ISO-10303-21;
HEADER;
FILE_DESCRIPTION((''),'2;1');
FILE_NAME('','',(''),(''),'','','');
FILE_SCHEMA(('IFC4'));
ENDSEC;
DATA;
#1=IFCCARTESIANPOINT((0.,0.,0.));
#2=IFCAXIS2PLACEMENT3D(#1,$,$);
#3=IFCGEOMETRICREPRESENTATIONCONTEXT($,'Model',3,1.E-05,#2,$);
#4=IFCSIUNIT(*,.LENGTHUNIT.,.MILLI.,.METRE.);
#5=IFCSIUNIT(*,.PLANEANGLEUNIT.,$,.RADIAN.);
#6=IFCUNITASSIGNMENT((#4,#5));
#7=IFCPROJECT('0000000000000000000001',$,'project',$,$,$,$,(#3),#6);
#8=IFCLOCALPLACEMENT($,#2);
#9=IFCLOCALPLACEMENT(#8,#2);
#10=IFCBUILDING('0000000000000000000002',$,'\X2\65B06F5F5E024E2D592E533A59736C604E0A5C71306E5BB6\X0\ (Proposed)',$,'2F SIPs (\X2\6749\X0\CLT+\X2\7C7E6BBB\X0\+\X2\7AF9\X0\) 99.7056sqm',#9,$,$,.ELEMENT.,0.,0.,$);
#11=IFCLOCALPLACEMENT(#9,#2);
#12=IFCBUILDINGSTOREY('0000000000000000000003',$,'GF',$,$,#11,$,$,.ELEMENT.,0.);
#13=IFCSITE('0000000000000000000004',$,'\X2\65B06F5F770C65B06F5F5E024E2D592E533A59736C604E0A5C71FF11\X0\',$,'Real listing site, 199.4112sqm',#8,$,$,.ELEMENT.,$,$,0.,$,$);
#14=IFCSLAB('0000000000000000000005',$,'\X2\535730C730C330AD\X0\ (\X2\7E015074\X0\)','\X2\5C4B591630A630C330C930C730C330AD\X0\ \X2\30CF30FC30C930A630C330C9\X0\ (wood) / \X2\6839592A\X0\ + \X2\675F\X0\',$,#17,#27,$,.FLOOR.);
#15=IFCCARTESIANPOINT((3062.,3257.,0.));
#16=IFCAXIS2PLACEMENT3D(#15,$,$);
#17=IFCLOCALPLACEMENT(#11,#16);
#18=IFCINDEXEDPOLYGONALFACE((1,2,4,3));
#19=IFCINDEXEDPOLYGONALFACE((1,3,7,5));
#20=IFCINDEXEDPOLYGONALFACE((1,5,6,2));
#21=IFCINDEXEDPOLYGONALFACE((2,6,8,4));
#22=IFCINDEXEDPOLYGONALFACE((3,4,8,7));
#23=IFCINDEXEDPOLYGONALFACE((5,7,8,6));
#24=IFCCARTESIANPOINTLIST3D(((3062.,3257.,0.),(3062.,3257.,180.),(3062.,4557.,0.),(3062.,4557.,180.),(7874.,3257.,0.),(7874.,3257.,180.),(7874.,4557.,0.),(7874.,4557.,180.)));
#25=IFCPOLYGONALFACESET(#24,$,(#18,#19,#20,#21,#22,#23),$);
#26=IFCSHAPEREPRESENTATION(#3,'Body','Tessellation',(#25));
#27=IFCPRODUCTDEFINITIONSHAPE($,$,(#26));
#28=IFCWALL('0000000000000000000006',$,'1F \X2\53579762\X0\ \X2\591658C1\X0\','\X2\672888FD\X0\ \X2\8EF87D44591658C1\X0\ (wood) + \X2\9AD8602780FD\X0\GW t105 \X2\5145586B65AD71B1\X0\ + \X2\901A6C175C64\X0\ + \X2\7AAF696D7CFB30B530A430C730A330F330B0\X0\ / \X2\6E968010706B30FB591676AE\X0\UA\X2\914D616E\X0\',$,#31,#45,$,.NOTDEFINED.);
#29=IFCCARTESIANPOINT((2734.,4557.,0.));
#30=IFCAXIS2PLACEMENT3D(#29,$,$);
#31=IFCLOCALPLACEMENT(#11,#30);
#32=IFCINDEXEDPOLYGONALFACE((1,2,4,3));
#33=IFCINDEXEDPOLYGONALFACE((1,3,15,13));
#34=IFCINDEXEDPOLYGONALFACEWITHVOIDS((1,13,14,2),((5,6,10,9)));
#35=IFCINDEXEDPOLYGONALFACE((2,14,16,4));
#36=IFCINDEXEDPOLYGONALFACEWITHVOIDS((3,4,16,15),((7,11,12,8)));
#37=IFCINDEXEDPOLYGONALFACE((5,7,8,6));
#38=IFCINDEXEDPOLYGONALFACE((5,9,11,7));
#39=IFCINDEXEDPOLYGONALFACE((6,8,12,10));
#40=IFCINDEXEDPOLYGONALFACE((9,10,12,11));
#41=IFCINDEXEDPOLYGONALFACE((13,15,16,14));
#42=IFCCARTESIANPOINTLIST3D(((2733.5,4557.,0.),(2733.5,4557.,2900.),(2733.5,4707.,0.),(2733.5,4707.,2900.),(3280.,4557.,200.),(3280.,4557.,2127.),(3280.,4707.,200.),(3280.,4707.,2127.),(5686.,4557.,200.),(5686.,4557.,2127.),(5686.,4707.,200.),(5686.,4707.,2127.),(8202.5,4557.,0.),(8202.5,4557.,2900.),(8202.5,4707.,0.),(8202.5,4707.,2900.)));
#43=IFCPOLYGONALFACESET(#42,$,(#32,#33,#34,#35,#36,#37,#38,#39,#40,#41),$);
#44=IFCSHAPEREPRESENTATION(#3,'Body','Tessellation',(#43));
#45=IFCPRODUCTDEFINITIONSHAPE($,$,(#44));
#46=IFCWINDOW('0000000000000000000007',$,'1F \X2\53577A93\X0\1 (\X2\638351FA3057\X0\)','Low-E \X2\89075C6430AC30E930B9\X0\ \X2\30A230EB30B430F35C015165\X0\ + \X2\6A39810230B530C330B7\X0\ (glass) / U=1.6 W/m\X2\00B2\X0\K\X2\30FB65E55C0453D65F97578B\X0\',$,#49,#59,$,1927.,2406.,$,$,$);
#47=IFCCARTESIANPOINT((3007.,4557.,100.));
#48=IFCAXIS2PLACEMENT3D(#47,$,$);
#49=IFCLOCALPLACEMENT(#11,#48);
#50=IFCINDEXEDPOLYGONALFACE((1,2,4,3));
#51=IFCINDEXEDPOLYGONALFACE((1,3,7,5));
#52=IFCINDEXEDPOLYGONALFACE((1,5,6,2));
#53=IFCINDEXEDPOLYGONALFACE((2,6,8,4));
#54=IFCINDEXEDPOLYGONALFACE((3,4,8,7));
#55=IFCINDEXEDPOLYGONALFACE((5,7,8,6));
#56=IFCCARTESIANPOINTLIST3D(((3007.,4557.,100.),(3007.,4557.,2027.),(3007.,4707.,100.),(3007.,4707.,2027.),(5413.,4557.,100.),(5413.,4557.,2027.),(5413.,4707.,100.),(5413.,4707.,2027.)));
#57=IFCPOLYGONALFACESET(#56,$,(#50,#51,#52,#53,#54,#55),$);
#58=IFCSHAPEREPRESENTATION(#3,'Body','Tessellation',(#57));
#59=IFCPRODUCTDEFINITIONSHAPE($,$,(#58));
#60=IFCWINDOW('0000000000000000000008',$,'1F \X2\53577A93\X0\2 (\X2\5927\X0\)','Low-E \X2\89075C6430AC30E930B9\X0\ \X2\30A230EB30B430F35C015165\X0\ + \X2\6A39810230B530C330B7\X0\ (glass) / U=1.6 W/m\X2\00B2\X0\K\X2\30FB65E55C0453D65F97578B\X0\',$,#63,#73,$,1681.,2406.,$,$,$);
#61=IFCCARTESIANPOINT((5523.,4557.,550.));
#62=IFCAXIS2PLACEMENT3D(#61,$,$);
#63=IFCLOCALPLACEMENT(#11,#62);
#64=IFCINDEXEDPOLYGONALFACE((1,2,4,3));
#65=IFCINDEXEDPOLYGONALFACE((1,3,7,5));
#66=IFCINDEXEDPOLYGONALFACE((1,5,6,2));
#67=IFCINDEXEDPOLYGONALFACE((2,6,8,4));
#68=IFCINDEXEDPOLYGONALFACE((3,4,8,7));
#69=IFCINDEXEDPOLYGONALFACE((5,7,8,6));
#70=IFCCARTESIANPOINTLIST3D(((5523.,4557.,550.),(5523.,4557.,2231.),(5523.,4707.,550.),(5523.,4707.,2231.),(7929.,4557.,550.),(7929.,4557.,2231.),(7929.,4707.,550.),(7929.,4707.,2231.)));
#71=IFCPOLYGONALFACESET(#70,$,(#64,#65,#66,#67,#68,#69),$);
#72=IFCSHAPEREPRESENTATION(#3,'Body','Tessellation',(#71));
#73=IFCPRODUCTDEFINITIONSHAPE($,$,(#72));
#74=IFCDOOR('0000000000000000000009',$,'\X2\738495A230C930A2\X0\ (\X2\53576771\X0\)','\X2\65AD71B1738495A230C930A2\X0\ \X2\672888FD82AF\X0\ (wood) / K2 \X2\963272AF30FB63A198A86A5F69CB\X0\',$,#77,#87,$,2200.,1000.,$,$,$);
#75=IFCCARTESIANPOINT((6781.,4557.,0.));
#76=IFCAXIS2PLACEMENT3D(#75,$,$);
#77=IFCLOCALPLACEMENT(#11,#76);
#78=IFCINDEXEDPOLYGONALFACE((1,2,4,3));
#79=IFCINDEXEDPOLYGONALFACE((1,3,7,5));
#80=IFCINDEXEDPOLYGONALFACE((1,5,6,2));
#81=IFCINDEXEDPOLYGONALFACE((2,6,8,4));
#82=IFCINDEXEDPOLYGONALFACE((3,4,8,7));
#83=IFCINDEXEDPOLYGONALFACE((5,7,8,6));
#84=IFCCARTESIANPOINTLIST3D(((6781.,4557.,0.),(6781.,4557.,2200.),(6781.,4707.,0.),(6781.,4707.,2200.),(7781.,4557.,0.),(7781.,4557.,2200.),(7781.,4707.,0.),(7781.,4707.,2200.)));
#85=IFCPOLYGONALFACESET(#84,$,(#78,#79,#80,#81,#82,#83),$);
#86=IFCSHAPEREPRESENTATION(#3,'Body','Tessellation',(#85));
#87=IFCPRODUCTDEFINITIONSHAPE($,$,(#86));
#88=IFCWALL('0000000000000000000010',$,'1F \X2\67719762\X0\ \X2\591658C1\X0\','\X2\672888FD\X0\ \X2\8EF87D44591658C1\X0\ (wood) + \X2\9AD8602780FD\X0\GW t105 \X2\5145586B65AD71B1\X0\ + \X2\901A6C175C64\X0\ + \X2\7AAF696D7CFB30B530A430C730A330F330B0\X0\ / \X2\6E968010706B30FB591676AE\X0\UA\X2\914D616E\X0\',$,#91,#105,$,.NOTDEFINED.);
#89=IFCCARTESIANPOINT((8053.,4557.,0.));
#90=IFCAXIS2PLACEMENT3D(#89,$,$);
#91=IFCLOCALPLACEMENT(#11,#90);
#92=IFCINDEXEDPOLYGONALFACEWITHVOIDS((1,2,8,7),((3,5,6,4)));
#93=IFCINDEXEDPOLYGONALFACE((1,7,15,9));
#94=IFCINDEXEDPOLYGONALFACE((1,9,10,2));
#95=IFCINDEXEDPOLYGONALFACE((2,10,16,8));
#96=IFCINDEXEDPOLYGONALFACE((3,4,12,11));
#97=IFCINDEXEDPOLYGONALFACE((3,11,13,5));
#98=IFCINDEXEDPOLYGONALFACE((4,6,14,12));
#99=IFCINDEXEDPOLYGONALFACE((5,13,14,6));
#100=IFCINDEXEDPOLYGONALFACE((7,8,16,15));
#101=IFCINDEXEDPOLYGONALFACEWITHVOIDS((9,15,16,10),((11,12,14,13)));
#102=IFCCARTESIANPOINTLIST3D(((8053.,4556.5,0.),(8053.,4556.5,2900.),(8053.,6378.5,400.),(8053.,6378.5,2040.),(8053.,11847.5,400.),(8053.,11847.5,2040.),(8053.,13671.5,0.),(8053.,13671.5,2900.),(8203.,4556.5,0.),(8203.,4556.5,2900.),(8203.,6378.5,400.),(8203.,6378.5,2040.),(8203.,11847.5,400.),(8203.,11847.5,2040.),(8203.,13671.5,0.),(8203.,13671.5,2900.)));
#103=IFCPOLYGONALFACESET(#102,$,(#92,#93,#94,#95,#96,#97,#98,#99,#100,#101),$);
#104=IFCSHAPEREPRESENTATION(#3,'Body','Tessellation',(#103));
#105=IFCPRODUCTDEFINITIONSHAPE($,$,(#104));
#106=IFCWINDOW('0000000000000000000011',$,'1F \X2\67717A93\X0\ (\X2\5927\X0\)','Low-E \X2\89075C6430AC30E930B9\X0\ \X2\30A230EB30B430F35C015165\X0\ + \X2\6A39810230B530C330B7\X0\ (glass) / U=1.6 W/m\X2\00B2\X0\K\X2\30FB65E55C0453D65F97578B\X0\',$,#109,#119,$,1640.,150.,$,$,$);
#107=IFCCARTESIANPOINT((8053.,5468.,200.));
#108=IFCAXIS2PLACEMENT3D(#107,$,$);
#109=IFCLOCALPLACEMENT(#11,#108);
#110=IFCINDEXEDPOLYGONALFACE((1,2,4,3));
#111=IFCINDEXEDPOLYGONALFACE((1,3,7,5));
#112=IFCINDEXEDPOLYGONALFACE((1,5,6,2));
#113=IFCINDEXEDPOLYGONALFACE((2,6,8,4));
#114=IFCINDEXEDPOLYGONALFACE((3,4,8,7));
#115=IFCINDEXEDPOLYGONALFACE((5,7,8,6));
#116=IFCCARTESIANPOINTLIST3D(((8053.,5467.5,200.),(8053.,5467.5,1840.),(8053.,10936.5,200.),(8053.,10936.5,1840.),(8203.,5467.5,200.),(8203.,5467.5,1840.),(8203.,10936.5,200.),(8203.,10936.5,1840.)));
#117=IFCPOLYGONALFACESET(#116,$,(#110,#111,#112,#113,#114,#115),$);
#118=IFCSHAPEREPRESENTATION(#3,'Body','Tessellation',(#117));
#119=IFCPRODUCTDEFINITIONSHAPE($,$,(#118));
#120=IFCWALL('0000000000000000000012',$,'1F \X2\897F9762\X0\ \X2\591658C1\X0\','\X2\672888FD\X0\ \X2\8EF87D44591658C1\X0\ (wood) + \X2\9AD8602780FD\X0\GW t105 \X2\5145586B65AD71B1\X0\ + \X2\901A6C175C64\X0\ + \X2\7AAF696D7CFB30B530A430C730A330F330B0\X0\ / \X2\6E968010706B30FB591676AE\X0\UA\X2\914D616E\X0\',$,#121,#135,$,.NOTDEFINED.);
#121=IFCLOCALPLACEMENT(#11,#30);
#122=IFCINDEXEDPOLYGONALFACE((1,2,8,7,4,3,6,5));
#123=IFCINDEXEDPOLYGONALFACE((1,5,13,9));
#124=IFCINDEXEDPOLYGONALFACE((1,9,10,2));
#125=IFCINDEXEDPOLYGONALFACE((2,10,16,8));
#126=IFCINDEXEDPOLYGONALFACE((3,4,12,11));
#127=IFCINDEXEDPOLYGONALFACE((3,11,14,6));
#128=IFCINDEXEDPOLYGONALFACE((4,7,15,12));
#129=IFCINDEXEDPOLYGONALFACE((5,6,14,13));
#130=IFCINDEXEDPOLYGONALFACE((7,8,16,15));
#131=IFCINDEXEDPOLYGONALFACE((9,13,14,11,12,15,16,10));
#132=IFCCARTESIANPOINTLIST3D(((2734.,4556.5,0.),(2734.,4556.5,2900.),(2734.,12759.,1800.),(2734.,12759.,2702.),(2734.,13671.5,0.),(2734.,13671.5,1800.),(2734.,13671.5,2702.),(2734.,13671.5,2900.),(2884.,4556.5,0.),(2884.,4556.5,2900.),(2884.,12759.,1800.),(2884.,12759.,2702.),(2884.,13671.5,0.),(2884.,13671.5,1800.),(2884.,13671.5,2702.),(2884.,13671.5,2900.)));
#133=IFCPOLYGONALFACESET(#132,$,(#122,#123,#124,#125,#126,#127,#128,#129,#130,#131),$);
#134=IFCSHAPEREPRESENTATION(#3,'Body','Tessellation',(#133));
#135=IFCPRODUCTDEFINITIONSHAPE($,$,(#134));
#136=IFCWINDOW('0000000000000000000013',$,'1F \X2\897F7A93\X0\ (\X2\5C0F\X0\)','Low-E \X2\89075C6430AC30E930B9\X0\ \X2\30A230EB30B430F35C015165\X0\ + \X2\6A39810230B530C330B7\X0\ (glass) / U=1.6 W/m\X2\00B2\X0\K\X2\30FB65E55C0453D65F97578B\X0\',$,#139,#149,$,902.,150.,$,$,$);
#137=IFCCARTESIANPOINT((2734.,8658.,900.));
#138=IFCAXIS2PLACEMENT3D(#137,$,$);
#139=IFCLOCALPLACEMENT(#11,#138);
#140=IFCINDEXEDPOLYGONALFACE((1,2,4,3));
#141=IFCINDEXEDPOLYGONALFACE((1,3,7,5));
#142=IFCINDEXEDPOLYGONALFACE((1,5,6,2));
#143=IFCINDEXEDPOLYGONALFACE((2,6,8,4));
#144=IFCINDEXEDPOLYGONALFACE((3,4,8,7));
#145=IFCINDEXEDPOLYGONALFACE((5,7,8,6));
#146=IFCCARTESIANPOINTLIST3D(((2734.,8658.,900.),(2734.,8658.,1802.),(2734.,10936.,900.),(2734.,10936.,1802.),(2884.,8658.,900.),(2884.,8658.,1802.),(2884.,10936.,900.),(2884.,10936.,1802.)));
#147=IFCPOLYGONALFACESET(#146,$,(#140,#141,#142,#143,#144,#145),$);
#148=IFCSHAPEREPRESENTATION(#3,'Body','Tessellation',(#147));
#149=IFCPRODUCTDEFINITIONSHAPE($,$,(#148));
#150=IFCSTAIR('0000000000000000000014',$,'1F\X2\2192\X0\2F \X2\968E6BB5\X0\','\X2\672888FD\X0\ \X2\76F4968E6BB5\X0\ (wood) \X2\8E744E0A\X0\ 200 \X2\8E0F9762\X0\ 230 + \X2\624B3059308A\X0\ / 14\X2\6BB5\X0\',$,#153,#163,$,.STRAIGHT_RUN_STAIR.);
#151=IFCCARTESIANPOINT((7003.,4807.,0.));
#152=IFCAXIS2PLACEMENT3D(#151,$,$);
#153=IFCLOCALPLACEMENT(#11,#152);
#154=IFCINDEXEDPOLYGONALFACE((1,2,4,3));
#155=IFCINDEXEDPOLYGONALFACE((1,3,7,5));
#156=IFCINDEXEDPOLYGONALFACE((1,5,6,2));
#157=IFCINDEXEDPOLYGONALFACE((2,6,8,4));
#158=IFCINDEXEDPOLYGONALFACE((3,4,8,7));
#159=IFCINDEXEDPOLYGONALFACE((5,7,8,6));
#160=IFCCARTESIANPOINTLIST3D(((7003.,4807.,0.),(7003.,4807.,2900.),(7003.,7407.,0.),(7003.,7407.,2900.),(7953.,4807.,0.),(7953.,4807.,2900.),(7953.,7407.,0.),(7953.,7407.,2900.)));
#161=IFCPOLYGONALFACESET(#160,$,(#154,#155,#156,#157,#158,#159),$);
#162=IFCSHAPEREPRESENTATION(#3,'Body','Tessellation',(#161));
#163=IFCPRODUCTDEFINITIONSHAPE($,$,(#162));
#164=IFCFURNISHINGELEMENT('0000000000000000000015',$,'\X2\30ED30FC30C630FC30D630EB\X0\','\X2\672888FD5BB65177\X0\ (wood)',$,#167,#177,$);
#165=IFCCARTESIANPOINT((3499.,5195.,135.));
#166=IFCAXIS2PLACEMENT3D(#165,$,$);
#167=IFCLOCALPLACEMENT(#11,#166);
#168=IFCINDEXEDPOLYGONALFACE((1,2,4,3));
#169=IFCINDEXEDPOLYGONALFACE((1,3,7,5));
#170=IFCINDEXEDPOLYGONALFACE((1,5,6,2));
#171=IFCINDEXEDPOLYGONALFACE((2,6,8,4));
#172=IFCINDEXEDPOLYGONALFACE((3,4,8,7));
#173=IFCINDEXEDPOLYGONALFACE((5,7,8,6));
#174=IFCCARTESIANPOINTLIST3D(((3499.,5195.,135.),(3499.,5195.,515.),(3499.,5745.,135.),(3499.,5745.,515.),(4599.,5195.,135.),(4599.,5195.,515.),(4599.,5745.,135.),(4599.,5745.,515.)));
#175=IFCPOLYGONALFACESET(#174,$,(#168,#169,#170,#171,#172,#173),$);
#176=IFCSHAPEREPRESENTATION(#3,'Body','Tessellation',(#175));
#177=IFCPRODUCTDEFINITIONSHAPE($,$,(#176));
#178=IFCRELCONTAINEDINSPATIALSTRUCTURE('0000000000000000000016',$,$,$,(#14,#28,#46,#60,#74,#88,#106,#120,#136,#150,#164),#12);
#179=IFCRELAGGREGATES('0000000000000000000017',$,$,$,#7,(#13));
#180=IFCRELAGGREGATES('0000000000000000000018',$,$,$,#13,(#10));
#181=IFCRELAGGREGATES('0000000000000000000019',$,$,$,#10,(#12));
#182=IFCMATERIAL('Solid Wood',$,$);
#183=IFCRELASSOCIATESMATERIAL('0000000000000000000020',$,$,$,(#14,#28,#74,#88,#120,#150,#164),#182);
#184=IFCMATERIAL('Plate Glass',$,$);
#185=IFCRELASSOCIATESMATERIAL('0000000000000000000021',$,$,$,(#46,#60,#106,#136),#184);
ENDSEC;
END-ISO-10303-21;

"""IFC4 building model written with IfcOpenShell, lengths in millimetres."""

from ifc_helpers import new_model, si_unit, frame, frame_2d, origin, place, context, project, spatial, rectangle, extrude, material, element, fill, save


model = new_model("IFC4")

# Units and contexts
model_context = context("Model", 3, precision=1e-05, world=origin())
ifc_project = project(units=[si_unit("LENGTHUNIT", "METRE", prefix="MILLI"), si_unit("PLANEANGLEUNIT", "RADIAN")], contexts=[model_context])

# Site, building, storey
site_placement = place(None, origin())
site = spatial("IfcSite", under=ifc_project, at=site_placement, Name="新潟県新潟市中央区女池上山１", ObjectType="Real listing site, 199.4112sqm", CompositionType="ELEMENT", RefElevation=0.0)
building_placement = place(site_placement, origin())
building = spatial("IfcBuilding", under=site, at=building_placement, Name="新潟市中央区女池上山の家 (Proposed)", ObjectType="2F SIPs (杉CLT+籾殻+竹) 99.7056sqm", CompositionType="ELEMENT", ElevationOfRefHeight=0.0, ElevationOfTerrain=0.0)
storey_placement = place(building_placement, origin())
storey = spatial("IfcBuildingStorey", under=building, at=storey_placement, Name="GF", CompositionType="ELEMENT", Elevation=0.0)

# Slab
ifc_material_1 = material(Name="Solid Wood")
slab_1_placement = place(storey_placement, frame((3062.0, 3257.0, 0.0)))
element("IfcSlab", 1, at=slab_1_placement, inside=storey, material=ifc_material_1, Name="南デッキ (縁側)", Description="屋外ウッドデッキ ハードウッド (wood) / 根太 + 束", PredefinedType="FLOOR", context=model_context, shape_type="SweptSolid", body=[
    extrude(rectangle(XDim=4812.0, YDim=1300.0, at=frame_2d((2406.0, 650.0))), frame((3062.0, 3257.0, 0.0)), (0.0, 0.0, 1.0), 180.0),
])

# Wall, openings, windows, door
wall_1_placement = place(storey_placement, frame((2734.0, 4557.0, 0.0)))
wall_1 = element("IfcWall", 2, at=wall_1_placement, inside=storey, material=ifc_material_1, Name="1F 南面 外壁", Description="木製 軸組外壁 (wood) + 高性能GW t105 充填断熱 + 通気層 + 窯業系サイディング / 準耐火・外皮UA配慮", PredefinedType="NOTDEFINED", context=model_context, shape_type="SweptSolid", body=[
    extrude(rectangle(XDim=5469.0, YDim=150.0, at=frame_2d((2734.0, 75.0))), frame((2734.0, 4557.0, 0.0)), (0.0, 0.0, 1.0), 2900.0),
])
opening_1_placement = place(storey_placement, frame((3007.0, 4557.0, 100.0)))
opening_1 = element("IfcOpeningElement", 3, at=opening_1_placement, cuts=wall_1, PredefinedType="NOTDEFINED", context=model_context, shape_type="SweptSolid", body=[
    extrude(rectangle(XDim=2406.0, YDim=150.0, at=frame_2d((1203.0, 75.0))), frame((3007.0, 4557.0, 100.0)), (0.0, 0.0, 1.0), 1927.0),
])
opening_2_placement = place(storey_placement, frame((5523.0, 4557.0, 550.0)))
opening_2 = element("IfcOpeningElement", 4, at=opening_2_placement, cuts=wall_1, PredefinedType="NOTDEFINED", context=model_context, shape_type="SweptSolid", body=[
    extrude(rectangle(XDim=2406.0, YDim=150.0, at=frame_2d((1203.0, 75.0))), frame((5523.0, 4557.0, 550.0)), (0.0, 0.0, 1.0), 1681.0),
])
opening_3_placement = place(storey_placement, frame((6781.0, 4557.0, 0.0)))
opening_3 = element("IfcOpeningElement", 5, at=opening_3_placement, cuts=wall_1, PredefinedType="NOTDEFINED", context=model_context, shape_type="SweptSolid", body=[
    extrude(rectangle(XDim=1000.0, YDim=150.0, at=frame_2d((500.0, 75.0))), frame((6781.0, 4557.0, 0.0)), (0.0, 0.0, 1.0), 2200.0),
])
ifc_material_2 = material(Name="Plate Glass")
window_1_placement = place(storey_placement, frame((3007.0, 4557.0, 100.0)))
window_1 = element("IfcWindow", 6, at=window_1_placement, inside=storey, material=ifc_material_2, Name="1F 南窓1 (掃出し)", Description="Low-E 複層ガラス アルゴン封入 + 樹脂サッシ (glass) / U=1.6 W/m²K・日射取得型", OverallHeight=1927.0, OverallWidth=2406.0, context=model_context, shape_type="SweptSolid", body=[
    extrude(rectangle(XDim=2406.0, YDim=150.0, at=frame_2d((1203.0, 75.0))), frame((3007.0, 4557.0, 100.0)), (0.0, 0.0, 1.0), 1927.0),
])
fill(opening_1, window_1)
window_2_placement = place(storey_placement, frame((5523.0, 4557.0, 550.0)))
window_2 = element("IfcWindow", 7, at=window_2_placement, inside=storey, material=ifc_material_2, Name="1F 南窓2 (大)", Description="Low-E 複層ガラス アルゴン封入 + 樹脂サッシ (glass) / U=1.6 W/m²K・日射取得型", OverallHeight=1681.0, OverallWidth=2406.0, context=model_context, shape_type="SweptSolid", body=[
    extrude(rectangle(XDim=2406.0, YDim=150.0, at=frame_2d((1203.0, 75.0))), frame((5523.0, 4557.0, 550.0)), (0.0, 0.0, 1.0), 1681.0),
])
fill(opening_2, window_2)
door_placement = place(storey_placement, frame((6781.0, 4557.0, 0.0)))
door = element("IfcDoor", 8, at=door_placement, inside=storey, material=ifc_material_1, Name="玄関ドア (南東)", Description="断熱玄関ドア 木製芯 (wood) / K2 防犯・採風機構", OverallHeight=2200.0, OverallWidth=1000.0, context=model_context, shape_type="SweptSolid", body=[
    extrude(rectangle(XDim=1000.0, YDim=150.0, at=frame_2d((500.0, 75.0))), frame((6781.0, 4557.0, 0.0)), (0.0, 0.0, 1.0), 2200.0),
])
fill(opening_3, door)

# Walls, openings, windows
wall_2_placement = place(storey_placement, frame((8053.0, 4557.0, 0.0)))
wall_2 = element("IfcWall", 9, at=wall_2_placement, inside=storey, material=ifc_material_1, Name="1F 東面 外壁", Description="木製 軸組外壁 (wood) + 高性能GW t105 充填断熱 + 通気層 + 窯業系サイディング / 準耐火・外皮UA配慮", PredefinedType="NOTDEFINED", context=model_context, shape_type="SweptSolid", body=[
    extrude(rectangle(XDim=150.0, YDim=9115.0, at=frame_2d((75.0, 4557.0))), frame((8053.0, 4557.0, 0.0)), (0.0, 0.0, 1.0), 2900.0),
])
opening_4_placement = place(storey_placement, frame((8053.0, 5468.0, 200.0)))
opening_4 = element("IfcOpeningElement", 10, at=opening_4_placement, cuts=wall_2, PredefinedType="NOTDEFINED", context=model_context, shape_type="SweptSolid", body=[
    extrude(rectangle(XDim=150.0, YDim=5469.0, at=frame_2d((75.0, 2734.0))), frame((8053.0, 5468.0, 200.0)), (0.0, 0.0, 1.0), 1640.0),
])
window_3_placement = place(storey_placement, frame((8053.0, 5468.0, 200.0)))
window_3 = element("IfcWindow", 11, at=window_3_placement, inside=storey, material=ifc_material_2, Name="1F 東窓 (大)", Description="Low-E 複層ガラス アルゴン封入 + 樹脂サッシ (glass) / U=1.6 W/m²K・日射取得型", OverallHeight=1640.0, OverallWidth=150.0, context=model_context, shape_type="SweptSolid", body=[
    extrude(rectangle(XDim=150.0, YDim=5469.0, at=frame_2d((75.0, 2734.0))), frame((8053.0, 5468.0, 200.0)), (0.0, 0.0, 1.0), 1640.0),
])
fill(opening_4, window_3)
wall_3_placement = place(storey_placement, frame((2734.0, 4557.0, 0.0)))
wall_3 = element("IfcWall", 12, at=wall_3_placement, inside=storey, material=ifc_material_1, Name="1F 西面 外壁", Description="木製 軸組外壁 (wood) + 高性能GW t105 充填断熱 + 通気層 + 窯業系サイディング / 準耐火・外皮UA配慮", PredefinedType="NOTDEFINED", context=model_context, shape_type="SweptSolid", body=[
    extrude(rectangle(XDim=150.0, YDim=9115.0, at=frame_2d((75.0, 4557.0))), frame((2734.0, 4557.0, 0.0)), (0.0, 0.0, 1.0), 2900.0),
])
opening_5_placement = place(storey_placement, frame((2734.0, 8658.0, 900.0)))
opening_5 = element("IfcOpeningElement", 13, at=opening_5_placement, cuts=wall_3, PredefinedType="NOTDEFINED", context=model_context, shape_type="SweptSolid", body=[
    extrude(rectangle(XDim=150.0, YDim=2278.0, at=frame_2d((75.0, 1139.0))), frame((2734.0, 8658.0, 900.0)), (0.0, 0.0, 1.0), 902.0),
])
window_4_placement = place(storey_placement, frame((2734.0, 8658.0, 900.0)))
window_4 = element("IfcWindow", 14, at=window_4_placement, inside=storey, material=ifc_material_2, Name="1F 西窓 (小)", Description="Low-E 複層ガラス アルゴン封入 + 樹脂サッシ (glass) / U=1.6 W/m²K・日射取得型", OverallHeight=902.0, OverallWidth=150.0, context=model_context, shape_type="SweptSolid", body=[
    extrude(rectangle(XDim=150.0, YDim=2278.0, at=frame_2d((75.0, 1139.0))), frame((2734.0, 8658.0, 900.0)), (0.0, 0.0, 1.0), 902.0),
])
fill(opening_5, window_4)

# Stair
stair_placement = place(storey_placement, frame((7003.0, 4807.0, 0.0)))
element("IfcStair", 15, at=stair_placement, inside=storey, material=ifc_material_1, Name="1F→2F 階段", Description="木製 直階段 (wood) 蹴上 200 踏面 230 + 手すり / 14段", PredefinedType="STRAIGHT_RUN_STAIR", context=model_context, shape_type="SweptSolid", body=[
    extrude(rectangle(XDim=950.0, YDim=2600.0, at=frame_2d((475.0, 1300.0))), frame((7003.0, 4807.0, 0.0)), (0.0, 0.0, 1.0), 2900.0),
])

# Furnishing element
furnishing_1_placement = place(storey_placement, frame((3499.0, 5195.0, 135.0)))
element("IfcFurnishingElement", 16, at=furnishing_1_placement, inside=storey, material=ifc_material_1, Name="ローテーブル", Description="木製家具 (wood)", context=model_context, shape_type="SweptSolid", body=[
    extrude(rectangle(XDim=1100.0, YDim=550.0, at=frame_2d((550.0, 275.0))), frame((3499.0, 5195.0, 135.0)), (0.0, 0.0, 1.0), 380.0),
])

save(model, "model.ifc")
